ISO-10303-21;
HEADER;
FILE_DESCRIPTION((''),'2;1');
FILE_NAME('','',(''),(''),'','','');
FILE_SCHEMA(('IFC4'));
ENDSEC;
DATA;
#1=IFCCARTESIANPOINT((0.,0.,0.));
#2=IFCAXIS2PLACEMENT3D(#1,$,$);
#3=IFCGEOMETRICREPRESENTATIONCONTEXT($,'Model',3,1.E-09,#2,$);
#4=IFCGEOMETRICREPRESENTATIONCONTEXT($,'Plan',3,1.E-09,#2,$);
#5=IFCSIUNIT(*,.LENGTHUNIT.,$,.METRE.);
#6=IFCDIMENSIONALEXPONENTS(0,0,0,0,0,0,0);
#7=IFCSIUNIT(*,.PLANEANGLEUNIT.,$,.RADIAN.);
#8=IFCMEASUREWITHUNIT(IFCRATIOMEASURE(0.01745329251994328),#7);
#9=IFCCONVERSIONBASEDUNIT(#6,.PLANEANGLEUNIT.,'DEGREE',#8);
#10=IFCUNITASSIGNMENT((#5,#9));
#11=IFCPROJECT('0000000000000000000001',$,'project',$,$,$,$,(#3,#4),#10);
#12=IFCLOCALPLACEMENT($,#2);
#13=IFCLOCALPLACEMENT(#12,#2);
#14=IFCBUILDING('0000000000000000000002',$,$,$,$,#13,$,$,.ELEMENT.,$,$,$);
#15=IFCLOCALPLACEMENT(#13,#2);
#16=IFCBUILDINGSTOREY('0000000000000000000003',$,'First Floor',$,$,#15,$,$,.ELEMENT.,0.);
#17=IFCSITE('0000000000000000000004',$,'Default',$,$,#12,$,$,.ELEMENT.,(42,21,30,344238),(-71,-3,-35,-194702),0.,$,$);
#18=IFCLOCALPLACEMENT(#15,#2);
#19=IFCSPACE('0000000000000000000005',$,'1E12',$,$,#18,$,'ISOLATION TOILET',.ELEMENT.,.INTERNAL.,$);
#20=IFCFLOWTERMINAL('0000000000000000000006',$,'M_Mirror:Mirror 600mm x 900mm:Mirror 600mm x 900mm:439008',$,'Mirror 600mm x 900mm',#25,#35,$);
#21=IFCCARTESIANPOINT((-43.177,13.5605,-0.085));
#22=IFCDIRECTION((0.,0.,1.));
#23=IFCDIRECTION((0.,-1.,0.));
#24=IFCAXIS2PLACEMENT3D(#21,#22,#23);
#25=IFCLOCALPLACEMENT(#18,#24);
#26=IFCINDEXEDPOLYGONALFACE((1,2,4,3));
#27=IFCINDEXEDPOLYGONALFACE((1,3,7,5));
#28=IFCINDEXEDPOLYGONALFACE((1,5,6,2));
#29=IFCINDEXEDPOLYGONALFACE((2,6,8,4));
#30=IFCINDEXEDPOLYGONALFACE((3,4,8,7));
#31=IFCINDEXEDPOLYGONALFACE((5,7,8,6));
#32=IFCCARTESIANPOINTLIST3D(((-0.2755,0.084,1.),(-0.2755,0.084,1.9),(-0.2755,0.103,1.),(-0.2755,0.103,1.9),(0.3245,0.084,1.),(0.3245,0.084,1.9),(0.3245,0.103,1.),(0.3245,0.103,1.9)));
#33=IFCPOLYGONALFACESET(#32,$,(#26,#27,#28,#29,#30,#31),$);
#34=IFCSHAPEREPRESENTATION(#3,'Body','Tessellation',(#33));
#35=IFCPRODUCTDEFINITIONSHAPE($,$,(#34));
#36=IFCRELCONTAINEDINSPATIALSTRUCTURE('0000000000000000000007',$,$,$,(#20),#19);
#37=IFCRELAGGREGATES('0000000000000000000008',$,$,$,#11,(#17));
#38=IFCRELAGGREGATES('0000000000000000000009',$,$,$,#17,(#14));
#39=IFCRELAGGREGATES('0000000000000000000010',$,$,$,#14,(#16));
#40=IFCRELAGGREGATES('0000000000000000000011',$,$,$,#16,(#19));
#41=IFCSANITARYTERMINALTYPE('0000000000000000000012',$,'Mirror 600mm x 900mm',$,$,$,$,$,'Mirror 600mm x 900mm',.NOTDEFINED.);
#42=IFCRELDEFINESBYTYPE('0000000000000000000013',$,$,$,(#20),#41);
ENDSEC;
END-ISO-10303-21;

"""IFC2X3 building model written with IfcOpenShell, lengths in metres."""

from ifc_helpers import new_model, entity, si_unit, converted_unit, frame, origin, origin_2d_with_axis, place, context, project, spatial, rectangle, extrude, source, transform, mapped, type_object, type_shapes, element, save


model = new_model("IFC2X3")

# Units and contexts
model_context = context("Model", 3, precision=1e-09, world=origin())
plan_context = context("Plan", 3, precision=1e-09, world=origin())
ifc_project = project(units=[si_unit("LENGTHUNIT", "METRE"), converted_unit("PLANEANGLEUNIT", "DEGREE", entity("IfcRatioMeasure", 0.01745329251994328), si_unit("PLANEANGLEUNIT", "RADIAN"), dimensions=[0, 0, 0, 0, 0, 0, 0])], contexts=[model_context, plan_context])

# Site, building, storey
site_placement = place(None, origin())
site = spatial("IfcSite", under=ifc_project, at=site_placement, Name="Default", CompositionType="ELEMENT", RefLatitude=(42, 21, 30, 344238), RefLongitude=(-71, -3, -35, -194702), RefElevation=0.0)
building_placement = place(site_placement, origin())
building = spatial("IfcBuilding", under=site, at=building_placement, CompositionType="ELEMENT")
storey_placement = place(building_placement, origin())
storey = spatial("IfcBuildingStorey", under=building, at=storey_placement, Name="First Floor", CompositionType="ELEMENT", Elevation=0.0)

# Shared definitions
space_placement = place(storey_placement, origin())
space = spatial("IfcSpace", under=storey, at=space_placement, Name="1E12", LongName="ISOLATION TOILET", CompositionType="ELEMENT", InteriorOrExteriorSpace="INTERNAL")

# Flow terminal
sanitary_terminal_type = type_object("IfcSanitaryTerminalType", Name="Mirror 600mm x 900mm", ElementType="Mirror 600mm x 900mm", PredefinedType="NOTDEFINED")
shared_shape_1 = source(origin(), model_context, "Body", "SweptSolid", [
    extrude(rectangle(XDim=0.0191, YDim=0.6, at=origin_2d_with_axis()), frame((0.0245, 0.0935, 1.0), z_axis=(0.0, 0.0, 1.0), x_axis=(0.0, -1.0, 0.0)), (0.0, 0.0, 1.0), 0.9),
])
type_shapes(sanitary_terminal_type, [shared_shape_1])
flow_terminal_placement = place(space_placement, frame((-43.177, 13.5605, -0.085), z_axis=(0.0, 0.0, 1.0), x_axis=(0.0, -1.0, 0.0)))
element("IfcFlowTerminal", 1, at=flow_terminal_placement, inside=space, type_object=sanitary_terminal_type, Name="M_Mirror:Mirror 600mm x 900mm:Mirror 600mm x 900mm:439008", ObjectType="Mirror 600mm x 900mm", context=model_context, shape_type="MappedRepresentation", body=[
    mapped(shared_shape_1, transform((0.0, 0.0, 0.0), scale=1.0)),
])

save(model, "model.ifc")
